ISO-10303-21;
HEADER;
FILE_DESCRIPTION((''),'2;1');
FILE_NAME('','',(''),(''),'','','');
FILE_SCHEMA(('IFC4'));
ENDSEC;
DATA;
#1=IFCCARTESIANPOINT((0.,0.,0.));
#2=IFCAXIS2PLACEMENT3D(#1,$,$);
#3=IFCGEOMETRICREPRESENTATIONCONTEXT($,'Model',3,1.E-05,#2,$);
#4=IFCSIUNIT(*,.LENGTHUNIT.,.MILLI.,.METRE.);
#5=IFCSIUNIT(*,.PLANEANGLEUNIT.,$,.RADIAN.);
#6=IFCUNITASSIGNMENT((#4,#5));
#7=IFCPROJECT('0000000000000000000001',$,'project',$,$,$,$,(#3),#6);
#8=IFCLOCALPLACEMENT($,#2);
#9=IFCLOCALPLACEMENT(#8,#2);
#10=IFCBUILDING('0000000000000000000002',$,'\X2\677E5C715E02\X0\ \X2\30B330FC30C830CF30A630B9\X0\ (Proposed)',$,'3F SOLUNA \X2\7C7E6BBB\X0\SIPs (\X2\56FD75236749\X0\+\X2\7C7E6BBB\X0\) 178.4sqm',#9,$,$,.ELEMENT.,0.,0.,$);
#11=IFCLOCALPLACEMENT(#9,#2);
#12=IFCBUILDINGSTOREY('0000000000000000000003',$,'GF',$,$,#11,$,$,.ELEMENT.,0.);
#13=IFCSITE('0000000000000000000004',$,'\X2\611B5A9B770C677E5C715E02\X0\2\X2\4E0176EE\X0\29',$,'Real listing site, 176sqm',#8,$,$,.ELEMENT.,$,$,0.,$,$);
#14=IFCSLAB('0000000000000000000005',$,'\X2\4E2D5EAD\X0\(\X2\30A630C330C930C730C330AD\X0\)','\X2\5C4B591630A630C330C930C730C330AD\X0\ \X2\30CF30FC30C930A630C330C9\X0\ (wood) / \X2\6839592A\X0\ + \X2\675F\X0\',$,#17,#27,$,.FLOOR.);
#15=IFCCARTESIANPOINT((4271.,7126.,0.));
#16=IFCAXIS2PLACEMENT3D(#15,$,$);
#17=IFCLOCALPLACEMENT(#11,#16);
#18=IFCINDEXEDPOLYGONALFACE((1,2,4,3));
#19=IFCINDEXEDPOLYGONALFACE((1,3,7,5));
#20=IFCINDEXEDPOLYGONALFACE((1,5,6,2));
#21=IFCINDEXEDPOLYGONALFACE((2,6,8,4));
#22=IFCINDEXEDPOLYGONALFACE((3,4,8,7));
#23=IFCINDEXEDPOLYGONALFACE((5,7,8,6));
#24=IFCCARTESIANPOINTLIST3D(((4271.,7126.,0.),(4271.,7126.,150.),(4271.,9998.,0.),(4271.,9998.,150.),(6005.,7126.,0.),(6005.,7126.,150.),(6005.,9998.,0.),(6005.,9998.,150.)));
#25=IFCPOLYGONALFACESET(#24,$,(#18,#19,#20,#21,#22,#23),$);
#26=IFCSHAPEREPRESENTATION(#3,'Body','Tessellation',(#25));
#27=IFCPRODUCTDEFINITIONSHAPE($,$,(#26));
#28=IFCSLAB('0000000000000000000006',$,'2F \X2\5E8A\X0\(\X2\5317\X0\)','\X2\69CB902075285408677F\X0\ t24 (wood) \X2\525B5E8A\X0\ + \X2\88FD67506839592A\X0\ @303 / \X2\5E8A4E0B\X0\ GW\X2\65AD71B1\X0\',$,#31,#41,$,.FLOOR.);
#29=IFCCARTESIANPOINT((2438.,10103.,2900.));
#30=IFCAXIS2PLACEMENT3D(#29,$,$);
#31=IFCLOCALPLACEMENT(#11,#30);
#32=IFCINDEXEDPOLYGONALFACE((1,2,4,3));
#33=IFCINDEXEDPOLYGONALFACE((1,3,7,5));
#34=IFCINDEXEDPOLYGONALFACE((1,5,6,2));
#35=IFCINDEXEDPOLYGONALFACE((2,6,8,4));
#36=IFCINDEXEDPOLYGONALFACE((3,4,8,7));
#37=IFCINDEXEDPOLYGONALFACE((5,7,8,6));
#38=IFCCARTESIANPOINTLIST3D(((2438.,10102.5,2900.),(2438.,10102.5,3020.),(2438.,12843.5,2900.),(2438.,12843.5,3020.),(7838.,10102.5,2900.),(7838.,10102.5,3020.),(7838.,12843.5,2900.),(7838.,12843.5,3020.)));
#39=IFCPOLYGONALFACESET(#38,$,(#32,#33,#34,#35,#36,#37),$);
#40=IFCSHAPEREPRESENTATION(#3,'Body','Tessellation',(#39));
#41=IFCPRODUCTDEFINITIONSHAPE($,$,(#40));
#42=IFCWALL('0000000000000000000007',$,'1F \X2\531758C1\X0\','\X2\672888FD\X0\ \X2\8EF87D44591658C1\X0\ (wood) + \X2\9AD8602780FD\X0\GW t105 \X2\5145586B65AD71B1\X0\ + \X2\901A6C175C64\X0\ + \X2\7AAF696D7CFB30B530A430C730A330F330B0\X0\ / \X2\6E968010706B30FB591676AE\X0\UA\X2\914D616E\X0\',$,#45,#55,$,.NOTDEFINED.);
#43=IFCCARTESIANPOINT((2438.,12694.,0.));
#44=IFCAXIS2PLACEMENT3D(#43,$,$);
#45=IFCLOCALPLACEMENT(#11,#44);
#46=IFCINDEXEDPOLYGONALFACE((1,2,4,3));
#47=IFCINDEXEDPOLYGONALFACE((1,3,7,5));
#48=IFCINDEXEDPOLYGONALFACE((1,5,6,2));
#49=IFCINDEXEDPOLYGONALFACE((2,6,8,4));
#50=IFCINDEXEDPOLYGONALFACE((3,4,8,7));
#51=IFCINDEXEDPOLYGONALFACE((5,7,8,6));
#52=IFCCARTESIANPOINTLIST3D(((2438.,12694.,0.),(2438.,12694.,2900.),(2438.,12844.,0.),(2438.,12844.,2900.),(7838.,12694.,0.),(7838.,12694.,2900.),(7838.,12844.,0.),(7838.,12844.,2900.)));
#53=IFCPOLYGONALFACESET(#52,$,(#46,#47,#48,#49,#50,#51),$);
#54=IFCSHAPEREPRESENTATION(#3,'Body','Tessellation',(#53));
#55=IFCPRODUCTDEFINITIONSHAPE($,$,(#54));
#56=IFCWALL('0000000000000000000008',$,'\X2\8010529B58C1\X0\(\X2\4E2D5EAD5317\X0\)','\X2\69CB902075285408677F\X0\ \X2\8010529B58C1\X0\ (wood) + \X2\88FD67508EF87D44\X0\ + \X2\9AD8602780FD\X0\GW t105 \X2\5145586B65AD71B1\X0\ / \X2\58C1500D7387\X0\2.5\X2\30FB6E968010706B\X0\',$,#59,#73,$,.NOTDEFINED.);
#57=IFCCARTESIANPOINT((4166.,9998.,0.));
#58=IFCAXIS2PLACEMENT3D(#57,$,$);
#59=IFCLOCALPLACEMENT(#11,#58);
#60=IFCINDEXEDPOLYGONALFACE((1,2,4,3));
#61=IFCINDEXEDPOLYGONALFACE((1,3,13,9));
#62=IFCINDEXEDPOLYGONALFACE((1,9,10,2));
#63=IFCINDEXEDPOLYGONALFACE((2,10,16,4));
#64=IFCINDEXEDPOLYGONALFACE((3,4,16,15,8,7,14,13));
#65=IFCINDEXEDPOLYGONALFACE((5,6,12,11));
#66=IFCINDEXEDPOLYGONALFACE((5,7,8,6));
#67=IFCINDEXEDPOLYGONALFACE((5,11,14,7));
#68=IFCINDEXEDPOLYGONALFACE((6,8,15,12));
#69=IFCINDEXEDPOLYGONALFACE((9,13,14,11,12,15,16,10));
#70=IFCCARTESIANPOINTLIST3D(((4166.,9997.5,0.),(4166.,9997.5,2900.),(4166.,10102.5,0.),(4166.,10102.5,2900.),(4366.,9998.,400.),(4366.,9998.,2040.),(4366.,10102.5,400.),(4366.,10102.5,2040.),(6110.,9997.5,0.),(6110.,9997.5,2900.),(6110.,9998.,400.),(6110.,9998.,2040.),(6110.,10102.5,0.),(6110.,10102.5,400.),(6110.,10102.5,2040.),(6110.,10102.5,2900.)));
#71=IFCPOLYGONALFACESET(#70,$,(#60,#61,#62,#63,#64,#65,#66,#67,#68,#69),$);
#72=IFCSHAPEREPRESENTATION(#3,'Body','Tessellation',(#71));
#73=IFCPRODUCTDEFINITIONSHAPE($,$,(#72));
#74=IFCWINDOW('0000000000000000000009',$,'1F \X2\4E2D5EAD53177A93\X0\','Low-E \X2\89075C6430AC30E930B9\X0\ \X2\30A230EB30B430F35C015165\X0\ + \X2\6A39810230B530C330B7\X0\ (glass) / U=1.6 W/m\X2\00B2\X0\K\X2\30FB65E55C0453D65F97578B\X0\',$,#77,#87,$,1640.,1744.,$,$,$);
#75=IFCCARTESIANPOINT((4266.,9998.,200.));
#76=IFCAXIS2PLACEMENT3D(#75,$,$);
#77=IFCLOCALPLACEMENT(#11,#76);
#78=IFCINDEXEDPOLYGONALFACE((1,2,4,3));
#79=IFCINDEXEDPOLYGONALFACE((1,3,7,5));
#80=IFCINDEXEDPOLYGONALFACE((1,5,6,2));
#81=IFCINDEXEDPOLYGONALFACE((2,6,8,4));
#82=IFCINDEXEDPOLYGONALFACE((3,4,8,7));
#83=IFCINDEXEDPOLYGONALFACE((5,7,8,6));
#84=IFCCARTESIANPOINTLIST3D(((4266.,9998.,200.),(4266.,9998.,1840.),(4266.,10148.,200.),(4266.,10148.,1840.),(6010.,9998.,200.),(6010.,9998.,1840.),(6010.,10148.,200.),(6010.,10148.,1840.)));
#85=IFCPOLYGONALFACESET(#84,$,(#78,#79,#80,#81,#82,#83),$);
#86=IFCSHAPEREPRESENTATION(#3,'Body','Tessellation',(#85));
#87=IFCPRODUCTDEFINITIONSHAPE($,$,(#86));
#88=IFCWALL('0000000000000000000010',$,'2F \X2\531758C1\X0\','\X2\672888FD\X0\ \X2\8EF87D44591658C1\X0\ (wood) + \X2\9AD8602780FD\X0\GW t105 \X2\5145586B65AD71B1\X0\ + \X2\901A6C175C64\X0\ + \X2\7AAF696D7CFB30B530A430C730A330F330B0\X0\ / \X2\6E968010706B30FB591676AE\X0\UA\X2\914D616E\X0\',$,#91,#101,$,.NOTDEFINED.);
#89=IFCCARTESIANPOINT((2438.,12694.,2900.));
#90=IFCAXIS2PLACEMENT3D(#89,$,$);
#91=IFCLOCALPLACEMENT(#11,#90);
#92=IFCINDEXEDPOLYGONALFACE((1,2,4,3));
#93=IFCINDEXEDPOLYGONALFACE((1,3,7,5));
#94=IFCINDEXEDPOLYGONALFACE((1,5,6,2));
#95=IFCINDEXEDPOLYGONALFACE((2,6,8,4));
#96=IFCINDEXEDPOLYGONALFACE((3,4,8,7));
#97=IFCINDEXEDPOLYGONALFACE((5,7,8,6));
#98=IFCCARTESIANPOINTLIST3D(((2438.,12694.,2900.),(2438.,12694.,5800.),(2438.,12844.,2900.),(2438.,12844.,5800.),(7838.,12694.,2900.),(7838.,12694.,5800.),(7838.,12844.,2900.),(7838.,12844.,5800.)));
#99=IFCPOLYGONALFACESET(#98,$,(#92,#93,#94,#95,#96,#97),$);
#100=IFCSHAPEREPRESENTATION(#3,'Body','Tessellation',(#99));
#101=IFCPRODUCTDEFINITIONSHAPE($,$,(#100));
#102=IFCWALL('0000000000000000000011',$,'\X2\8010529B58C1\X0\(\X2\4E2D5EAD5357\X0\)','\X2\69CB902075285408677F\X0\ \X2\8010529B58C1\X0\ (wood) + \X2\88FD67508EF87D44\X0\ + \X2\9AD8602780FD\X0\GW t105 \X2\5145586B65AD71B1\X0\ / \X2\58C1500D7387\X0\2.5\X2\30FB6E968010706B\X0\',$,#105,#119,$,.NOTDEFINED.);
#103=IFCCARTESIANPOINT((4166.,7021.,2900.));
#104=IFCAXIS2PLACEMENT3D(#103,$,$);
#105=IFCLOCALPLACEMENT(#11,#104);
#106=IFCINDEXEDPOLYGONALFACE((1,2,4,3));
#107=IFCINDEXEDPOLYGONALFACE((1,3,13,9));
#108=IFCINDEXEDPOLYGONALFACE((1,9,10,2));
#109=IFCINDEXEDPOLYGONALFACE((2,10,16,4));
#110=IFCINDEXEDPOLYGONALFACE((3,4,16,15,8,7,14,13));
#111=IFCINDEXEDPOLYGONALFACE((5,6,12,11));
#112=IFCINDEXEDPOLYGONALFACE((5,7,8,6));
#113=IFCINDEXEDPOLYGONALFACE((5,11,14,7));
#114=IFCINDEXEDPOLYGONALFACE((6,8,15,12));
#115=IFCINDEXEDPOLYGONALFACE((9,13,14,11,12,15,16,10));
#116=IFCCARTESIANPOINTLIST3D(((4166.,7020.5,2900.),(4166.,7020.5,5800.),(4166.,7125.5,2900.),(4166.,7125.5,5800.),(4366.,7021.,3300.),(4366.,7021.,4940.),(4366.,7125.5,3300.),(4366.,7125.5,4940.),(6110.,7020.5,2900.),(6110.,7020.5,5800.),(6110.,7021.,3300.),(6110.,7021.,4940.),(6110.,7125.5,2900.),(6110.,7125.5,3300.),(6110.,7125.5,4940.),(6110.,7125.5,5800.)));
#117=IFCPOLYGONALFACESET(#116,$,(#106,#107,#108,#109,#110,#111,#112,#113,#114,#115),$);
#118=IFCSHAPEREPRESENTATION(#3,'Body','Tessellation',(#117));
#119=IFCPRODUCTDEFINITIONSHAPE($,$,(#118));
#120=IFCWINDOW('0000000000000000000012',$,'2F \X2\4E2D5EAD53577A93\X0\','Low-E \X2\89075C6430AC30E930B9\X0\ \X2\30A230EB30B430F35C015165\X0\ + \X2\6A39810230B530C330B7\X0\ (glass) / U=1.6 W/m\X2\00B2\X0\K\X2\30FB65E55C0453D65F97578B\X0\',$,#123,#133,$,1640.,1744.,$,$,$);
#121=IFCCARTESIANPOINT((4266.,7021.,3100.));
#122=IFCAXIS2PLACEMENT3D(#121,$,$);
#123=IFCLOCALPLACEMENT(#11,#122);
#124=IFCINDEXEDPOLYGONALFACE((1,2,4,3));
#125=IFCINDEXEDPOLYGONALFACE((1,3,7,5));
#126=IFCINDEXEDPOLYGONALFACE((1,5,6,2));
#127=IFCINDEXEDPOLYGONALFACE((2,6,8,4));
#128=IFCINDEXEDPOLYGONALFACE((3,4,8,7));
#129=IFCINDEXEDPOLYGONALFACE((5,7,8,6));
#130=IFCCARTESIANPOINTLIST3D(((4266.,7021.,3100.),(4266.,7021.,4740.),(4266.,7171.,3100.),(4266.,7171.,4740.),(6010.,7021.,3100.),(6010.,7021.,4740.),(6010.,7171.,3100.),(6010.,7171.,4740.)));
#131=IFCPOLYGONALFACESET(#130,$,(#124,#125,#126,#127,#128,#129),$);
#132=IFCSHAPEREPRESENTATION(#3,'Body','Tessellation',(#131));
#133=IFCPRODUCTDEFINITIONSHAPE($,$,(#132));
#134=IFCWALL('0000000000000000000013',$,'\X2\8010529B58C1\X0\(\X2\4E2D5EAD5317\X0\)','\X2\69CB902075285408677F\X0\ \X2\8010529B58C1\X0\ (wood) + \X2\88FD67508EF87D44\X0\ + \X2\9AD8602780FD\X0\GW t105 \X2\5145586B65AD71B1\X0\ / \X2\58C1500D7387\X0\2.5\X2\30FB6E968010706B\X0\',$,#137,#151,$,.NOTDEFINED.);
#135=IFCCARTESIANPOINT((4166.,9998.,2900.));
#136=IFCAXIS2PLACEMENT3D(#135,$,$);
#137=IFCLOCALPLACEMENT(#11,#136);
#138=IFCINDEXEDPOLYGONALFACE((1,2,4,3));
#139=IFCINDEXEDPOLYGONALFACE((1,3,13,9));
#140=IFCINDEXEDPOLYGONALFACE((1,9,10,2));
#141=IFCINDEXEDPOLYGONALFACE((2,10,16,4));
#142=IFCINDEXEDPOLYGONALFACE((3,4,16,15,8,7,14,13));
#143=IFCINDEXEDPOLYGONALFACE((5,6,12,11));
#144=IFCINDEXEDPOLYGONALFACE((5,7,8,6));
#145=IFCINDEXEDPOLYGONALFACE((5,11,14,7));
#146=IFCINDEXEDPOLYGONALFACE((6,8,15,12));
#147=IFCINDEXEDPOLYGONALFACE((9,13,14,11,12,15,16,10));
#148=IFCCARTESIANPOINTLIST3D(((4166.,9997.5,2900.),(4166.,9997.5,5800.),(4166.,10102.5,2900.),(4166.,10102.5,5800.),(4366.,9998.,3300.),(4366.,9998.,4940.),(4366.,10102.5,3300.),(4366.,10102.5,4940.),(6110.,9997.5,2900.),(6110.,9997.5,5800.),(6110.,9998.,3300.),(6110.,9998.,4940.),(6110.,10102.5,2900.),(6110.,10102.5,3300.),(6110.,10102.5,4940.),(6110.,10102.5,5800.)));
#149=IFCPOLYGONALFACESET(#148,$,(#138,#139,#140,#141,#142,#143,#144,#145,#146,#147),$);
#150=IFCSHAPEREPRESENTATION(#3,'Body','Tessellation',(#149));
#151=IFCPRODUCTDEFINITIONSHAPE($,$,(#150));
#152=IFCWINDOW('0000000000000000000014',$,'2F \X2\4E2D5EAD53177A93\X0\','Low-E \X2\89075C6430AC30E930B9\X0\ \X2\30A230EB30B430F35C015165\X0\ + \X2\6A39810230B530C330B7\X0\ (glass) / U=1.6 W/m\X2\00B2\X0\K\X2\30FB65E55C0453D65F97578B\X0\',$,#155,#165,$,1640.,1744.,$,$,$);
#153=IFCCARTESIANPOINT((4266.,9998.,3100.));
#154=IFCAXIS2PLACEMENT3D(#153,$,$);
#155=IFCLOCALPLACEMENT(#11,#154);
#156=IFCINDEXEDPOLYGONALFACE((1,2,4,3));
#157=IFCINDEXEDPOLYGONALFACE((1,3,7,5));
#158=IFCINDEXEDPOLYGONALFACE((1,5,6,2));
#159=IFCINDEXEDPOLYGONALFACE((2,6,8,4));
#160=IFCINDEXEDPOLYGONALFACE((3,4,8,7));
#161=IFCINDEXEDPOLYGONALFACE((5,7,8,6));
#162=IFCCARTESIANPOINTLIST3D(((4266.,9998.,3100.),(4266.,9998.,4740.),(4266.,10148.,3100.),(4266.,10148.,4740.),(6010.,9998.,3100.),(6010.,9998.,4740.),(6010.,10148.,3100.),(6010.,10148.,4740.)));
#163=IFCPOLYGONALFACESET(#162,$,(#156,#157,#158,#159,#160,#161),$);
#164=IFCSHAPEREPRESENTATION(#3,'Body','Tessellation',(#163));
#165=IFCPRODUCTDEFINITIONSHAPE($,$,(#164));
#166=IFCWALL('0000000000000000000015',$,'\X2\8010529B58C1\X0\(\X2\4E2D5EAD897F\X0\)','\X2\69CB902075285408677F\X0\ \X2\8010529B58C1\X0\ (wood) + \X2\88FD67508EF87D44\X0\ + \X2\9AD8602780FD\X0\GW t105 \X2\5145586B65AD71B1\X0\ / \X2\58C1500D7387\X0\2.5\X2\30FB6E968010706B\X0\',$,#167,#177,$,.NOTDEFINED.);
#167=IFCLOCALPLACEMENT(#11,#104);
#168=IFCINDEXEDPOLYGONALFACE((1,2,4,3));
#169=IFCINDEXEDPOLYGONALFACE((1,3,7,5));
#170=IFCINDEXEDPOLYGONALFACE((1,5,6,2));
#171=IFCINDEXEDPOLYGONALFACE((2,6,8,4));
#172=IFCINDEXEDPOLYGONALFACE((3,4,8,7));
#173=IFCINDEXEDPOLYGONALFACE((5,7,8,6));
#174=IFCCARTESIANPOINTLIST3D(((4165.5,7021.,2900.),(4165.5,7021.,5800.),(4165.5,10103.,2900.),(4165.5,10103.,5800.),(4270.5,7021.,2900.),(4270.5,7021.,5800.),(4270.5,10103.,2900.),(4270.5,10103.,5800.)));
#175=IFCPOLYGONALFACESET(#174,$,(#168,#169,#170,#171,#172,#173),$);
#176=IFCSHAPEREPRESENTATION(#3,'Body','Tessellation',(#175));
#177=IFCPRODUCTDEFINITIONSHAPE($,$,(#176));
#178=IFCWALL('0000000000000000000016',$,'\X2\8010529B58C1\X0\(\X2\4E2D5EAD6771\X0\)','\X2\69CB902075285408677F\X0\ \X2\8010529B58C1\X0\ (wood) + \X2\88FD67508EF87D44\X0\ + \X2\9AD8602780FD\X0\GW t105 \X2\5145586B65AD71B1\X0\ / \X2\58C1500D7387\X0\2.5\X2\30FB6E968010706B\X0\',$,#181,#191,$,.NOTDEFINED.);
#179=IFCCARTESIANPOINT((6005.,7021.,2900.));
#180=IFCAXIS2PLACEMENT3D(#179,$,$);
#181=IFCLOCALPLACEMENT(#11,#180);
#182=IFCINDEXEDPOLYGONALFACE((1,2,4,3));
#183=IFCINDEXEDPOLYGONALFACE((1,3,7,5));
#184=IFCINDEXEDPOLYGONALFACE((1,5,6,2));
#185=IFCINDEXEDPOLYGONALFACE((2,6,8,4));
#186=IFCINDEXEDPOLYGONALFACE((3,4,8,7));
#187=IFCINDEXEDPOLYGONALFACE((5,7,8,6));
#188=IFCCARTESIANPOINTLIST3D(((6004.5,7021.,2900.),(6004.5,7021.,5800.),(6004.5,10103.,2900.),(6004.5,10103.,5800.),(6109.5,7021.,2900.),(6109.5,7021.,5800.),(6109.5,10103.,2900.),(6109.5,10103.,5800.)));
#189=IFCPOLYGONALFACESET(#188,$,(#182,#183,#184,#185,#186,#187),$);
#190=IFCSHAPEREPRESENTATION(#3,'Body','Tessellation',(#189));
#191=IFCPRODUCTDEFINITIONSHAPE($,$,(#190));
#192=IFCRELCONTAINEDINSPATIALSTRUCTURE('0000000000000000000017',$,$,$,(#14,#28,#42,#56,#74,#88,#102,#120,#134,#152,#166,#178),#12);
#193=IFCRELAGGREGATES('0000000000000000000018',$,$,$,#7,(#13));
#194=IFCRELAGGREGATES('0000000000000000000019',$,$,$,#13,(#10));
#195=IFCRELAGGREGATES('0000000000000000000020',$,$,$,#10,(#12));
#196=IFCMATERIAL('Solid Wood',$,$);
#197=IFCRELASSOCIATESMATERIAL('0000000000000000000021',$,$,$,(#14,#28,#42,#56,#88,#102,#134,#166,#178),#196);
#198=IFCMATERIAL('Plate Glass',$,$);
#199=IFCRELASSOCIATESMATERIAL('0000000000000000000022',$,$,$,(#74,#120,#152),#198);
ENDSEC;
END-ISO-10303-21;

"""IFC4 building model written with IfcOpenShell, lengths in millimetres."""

from ifc_helpers import new_model, si_unit, frame, frame_2d, origin, place, context, project, spatial, rectangle, extrude, material, element, fill, save


model = new_model("IFC4")

# Units and contexts
model_context = context("Model", 3, precision=1e-05, world=origin())
ifc_project = project(units=[si_unit("LENGTHUNIT", "METRE", prefix="MILLI"), si_unit("PLANEANGLEUNIT", "RADIAN")], contexts=[model_context])

# Site, building, storey
site_placement = place(None, origin())
site = spatial("IfcSite", under=ifc_project, at=site_placement, Name="愛媛県松山市2丁目29", ObjectType="Real listing site, 176sqm", CompositionType="ELEMENT", RefElevation=0.0)
building_placement = place(site_placement, origin())
building = spatial("IfcBuilding", under=site, at=building_placement, Name="松山市 コートハウス (Proposed)", ObjectType="3F SOLUNA 籾殻SIPs (国産杉+籾殻) 178.4sqm", CompositionType="ELEMENT", ElevationOfRefHeight=0.0, ElevationOfTerrain=0.0)
storey_placement = place(building_placement, origin())
storey = spatial("IfcBuildingStorey", under=building, at=storey_placement, Name="GF", CompositionType="ELEMENT", Elevation=0.0)

# Slabs
ifc_material_1 = material(Name="Solid Wood")
slab_1_placement = place(storey_placement, frame((4271.0, 7126.0, 0.0)))
element("IfcSlab", 1, at=slab_1_placement, inside=storey, material=ifc_material_1, Name="中庭(ウッドデッキ)", Description="屋外ウッドデッキ ハードウッド (wood) / 根太 + 束", PredefinedType="FLOOR", context=model_context, shape_type="SweptSolid", body=[
    extrude(rectangle(XDim=1734.0, YDim=2872.0, at=frame_2d((867.0, 1436.0))), frame((4271.0, 7126.0, 0.0)), (0.0, 0.0, 1.0), 150.0),
])
slab_2_placement = place(storey_placement, frame((2438.0, 10103.0, 2900.0)))
element("IfcSlab", 2, at=slab_2_placement, inside=storey, material=ifc_material_1, Name="2F 床(北)", Description="構造用合板 t24 (wood) 剛床 + 製材根太 @303 / 床下 GW断熱", PredefinedType="FLOOR", context=model_context, shape_type="SweptSolid", body=[
    extrude(rectangle(XDim=5400.0, YDim=2741.0, at=frame_2d((2700.0, 1370.0))), frame((2438.0, 10103.0, 2900.0)), (0.0, 0.0, 1.0), 120.0),
])

# Wall
wall_1_placement = place(storey_placement, frame((2438.0, 12694.0, 0.0)))
element("IfcWall", 3, at=wall_1_placement, inside=storey, material=ifc_material_1, Name="1F 北壁", Description="木製 軸組外壁 (wood) + 高性能GW t105 充填断熱 + 通気層 + 窯業系サイディング / 準耐火・外皮UA配慮", PredefinedType="NOTDEFINED", context=model_context, shape_type="SweptSolid", body=[
    extrude(rectangle(XDim=5400.0, YDim=150.0, at=frame_2d((2700.0, 75.0))), frame((2438.0, 12694.0, 0.0)), (0.0, 0.0, 1.0), 2900.0),
])

# Wall, opening, window
wall_2_placement = place(storey_placement, frame((4166.0, 9998.0, 0.0)))
wall_2 = element("IfcWall", 4, at=wall_2_placement, inside=storey, material=ifc_material_1, Name="耐力壁(中庭北)", Description="構造用合板 耐力壁 (wood) + 製材軸組 + 高性能GW t105 充填断熱 / 壁倍率2.5・準耐火", PredefinedType="NOTDEFINED", context=model_context, shape_type="SweptSolid", body=[
    extrude(rectangle(XDim=1944.0, YDim=105.0, at=frame_2d((972.0, 52.0))), frame((4166.0, 9998.0, 0.0)), (0.0, 0.0, 1.0), 2900.0),
])
opening_1_placement = place(storey_placement, frame((4266.0, 9998.0, 200.0)))
opening_1 = element("IfcOpeningElement", 5, at=opening_1_placement, cuts=wall_2, PredefinedType="NOTDEFINED", context=model_context, shape_type="SweptSolid", body=[
    extrude(rectangle(XDim=1744.0, YDim=150.0, at=frame_2d((872.0, 75.0))), frame((4266.0, 9998.0, 200.0)), (0.0, 0.0, 1.0), 1640.0),
])
ifc_material_2 = material(Name="Plate Glass")
window_1_placement = place(storey_placement, frame((4266.0, 9998.0, 200.0)))
window_1 = element("IfcWindow", 6, at=window_1_placement, inside=storey, material=ifc_material_2, Name="1F 中庭北窓", Description="Low-E 複層ガラス アルゴン封入 + 樹脂サッシ (glass) / U=1.6 W/m²K・日射取得型", OverallHeight=1640.0, OverallWidth=1744.0, context=model_context, shape_type="SweptSolid", body=[
    extrude(rectangle(XDim=1744.0, YDim=150.0, at=frame_2d((872.0, 75.0))), frame((4266.0, 9998.0, 200.0)), (0.0, 0.0, 1.0), 1640.0),
])
fill(opening_1, window_1)

# Wall
wall_3_placement = place(storey_placement, frame((2438.0, 12694.0, 2900.0)))
element("IfcWall", 7, at=wall_3_placement, inside=storey, material=ifc_material_1, Name="2F 北壁", Description="木製 軸組外壁 (wood) + 高性能GW t105 充填断熱 + 通気層 + 窯業系サイディング / 準耐火・外皮UA配慮", PredefinedType="NOTDEFINED", context=model_context, shape_type="SweptSolid", body=[
    extrude(rectangle(XDim=5400.0, YDim=150.0, at=frame_2d((2700.0, 75.0))), frame((2438.0, 12694.0, 2900.0)), (0.0, 0.0, 1.0), 2900.0),
])

# Walls, openings, windows
wall_4_placement = place(storey_placement, frame((4166.0, 7021.0, 2900.0)))
wall_4 = element("IfcWall", 8, at=wall_4_placement, inside=storey, material=ifc_material_1, Name="耐力壁(中庭南)", Description="構造用合板 耐力壁 (wood) + 製材軸組 + 高性能GW t105 充填断熱 / 壁倍率2.5・準耐火", PredefinedType="NOTDEFINED", context=model_context, shape_type="SweptSolid", body=[
    extrude(rectangle(XDim=1944.0, YDim=105.0, at=frame_2d((972.0, 52.0))), frame((4166.0, 7021.0, 2900.0)), (0.0, 0.0, 1.0), 2900.0),
])
opening_2_placement = place(storey_placement, frame((4266.0, 7021.0, 3100.0)))
opening_2 = element("IfcOpeningElement", 9, at=opening_2_placement, cuts=wall_4, PredefinedType="NOTDEFINED", context=model_context, shape_type="SweptSolid", body=[
    extrude(rectangle(XDim=1744.0, YDim=150.0, at=frame_2d((872.0, 75.0))), frame((4266.0, 7021.0, 3100.0)), (0.0, 0.0, 1.0), 1640.0),
])
window_2_placement = place(storey_placement, frame((4266.0, 7021.0, 3100.0)))
window_2 = element("IfcWindow", 10, at=window_2_placement, inside=storey, material=ifc_material_2, Name="2F 中庭南窓", Description="Low-E 複層ガラス アルゴン封入 + 樹脂サッシ (glass) / U=1.6 W/m²K・日射取得型", OverallHeight=1640.0, OverallWidth=1744.0, context=model_context, shape_type="SweptSolid", body=[
    extrude(rectangle(XDim=1744.0, YDim=150.0, at=frame_2d((872.0, 75.0))), frame((4266.0, 7021.0, 3100.0)), (0.0, 0.0, 1.0), 1640.0),
])
fill(opening_2, window_2)
wall_5_placement = place(storey_placement, frame((4166.0, 9998.0, 2900.0)))
wall_5 = element("IfcWall", 11, at=wall_5_placement, inside=storey, material=ifc_material_1, Name="耐力壁(中庭北)", Description="構造用合板 耐力壁 (wood) + 製材軸組 + 高性能GW t105 充填断熱 / 壁倍率2.5・準耐火", PredefinedType="NOTDEFINED", context=model_context, shape_type="SweptSolid", body=[
    extrude(rectangle(XDim=1944.0, YDim=105.0, at=frame_2d((972.0, 52.0))), frame((4166.0, 9998.0, 2900.0)), (0.0, 0.0, 1.0), 2900.0),
])
opening_3_placement = place(storey_placement, frame((4266.0, 9998.0, 3100.0)))
opening_3 = element("IfcOpeningElement", 12, at=opening_3_placement, cuts=wall_5, PredefinedType="NOTDEFINED", context=model_context, shape_type="SweptSolid", body=[
    extrude(rectangle(XDim=1744.0, YDim=150.0, at=frame_2d((872.0, 75.0))), frame((4266.0, 9998.0, 3100.0)), (0.0, 0.0, 1.0), 1640.0),
])
window_3_placement = place(storey_placement, frame((4266.0, 9998.0, 3100.0)))
window_3 = element("IfcWindow", 13, at=window_3_placement, inside=storey, material=ifc_material_2, Name="2F 中庭北窓", Description="Low-E 複層ガラス アルゴン封入 + 樹脂サッシ (glass) / U=1.6 W/m²K・日射取得型", OverallHeight=1640.0, OverallWidth=1744.0, context=model_context, shape_type="SweptSolid", body=[
    extrude(rectangle(XDim=1744.0, YDim=150.0, at=frame_2d((872.0, 75.0))), frame((4266.0, 9998.0, 3100.0)), (0.0, 0.0, 1.0), 1640.0),
])
fill(opening_3, window_3)

# Walls
wall_6_placement = place(storey_placement, frame((4166.0, 7021.0, 2900.0)))
element("IfcWall", 14, at=wall_6_placement, inside=storey, material=ifc_material_1, Name="耐力壁(中庭西)", Description="構造用合板 耐力壁 (wood) + 製材軸組 + 高性能GW t105 充填断熱 / 壁倍率2.5・準耐火", PredefinedType="NOTDEFINED", context=model_context, shape_type="SweptSolid", body=[
    extrude(rectangle(XDim=105.0, YDim=3082.0, at=frame_2d((52.0, 1541.0))), frame((4166.0, 7021.0, 2900.0)), (0.0, 0.0, 1.0), 2900.0),
])
wall_7_placement = place(storey_placement, frame((6005.0, 7021.0, 2900.0)))
element("IfcWall", 15, at=wall_7_placement, inside=storey, material=ifc_material_1, Name="耐力壁(中庭東)", Description="構造用合板 耐力壁 (wood) + 製材軸組 + 高性能GW t105 充填断熱 / 壁倍率2.5・準耐火", PredefinedType="NOTDEFINED", context=model_context, shape_type="SweptSolid", body=[
    extrude(rectangle(XDim=105.0, YDim=3082.0, at=frame_2d((52.0, 1541.0))), frame((6005.0, 7021.0, 2900.0)), (0.0, 0.0, 1.0), 2900.0),
])

save(model, "model.ifc")
